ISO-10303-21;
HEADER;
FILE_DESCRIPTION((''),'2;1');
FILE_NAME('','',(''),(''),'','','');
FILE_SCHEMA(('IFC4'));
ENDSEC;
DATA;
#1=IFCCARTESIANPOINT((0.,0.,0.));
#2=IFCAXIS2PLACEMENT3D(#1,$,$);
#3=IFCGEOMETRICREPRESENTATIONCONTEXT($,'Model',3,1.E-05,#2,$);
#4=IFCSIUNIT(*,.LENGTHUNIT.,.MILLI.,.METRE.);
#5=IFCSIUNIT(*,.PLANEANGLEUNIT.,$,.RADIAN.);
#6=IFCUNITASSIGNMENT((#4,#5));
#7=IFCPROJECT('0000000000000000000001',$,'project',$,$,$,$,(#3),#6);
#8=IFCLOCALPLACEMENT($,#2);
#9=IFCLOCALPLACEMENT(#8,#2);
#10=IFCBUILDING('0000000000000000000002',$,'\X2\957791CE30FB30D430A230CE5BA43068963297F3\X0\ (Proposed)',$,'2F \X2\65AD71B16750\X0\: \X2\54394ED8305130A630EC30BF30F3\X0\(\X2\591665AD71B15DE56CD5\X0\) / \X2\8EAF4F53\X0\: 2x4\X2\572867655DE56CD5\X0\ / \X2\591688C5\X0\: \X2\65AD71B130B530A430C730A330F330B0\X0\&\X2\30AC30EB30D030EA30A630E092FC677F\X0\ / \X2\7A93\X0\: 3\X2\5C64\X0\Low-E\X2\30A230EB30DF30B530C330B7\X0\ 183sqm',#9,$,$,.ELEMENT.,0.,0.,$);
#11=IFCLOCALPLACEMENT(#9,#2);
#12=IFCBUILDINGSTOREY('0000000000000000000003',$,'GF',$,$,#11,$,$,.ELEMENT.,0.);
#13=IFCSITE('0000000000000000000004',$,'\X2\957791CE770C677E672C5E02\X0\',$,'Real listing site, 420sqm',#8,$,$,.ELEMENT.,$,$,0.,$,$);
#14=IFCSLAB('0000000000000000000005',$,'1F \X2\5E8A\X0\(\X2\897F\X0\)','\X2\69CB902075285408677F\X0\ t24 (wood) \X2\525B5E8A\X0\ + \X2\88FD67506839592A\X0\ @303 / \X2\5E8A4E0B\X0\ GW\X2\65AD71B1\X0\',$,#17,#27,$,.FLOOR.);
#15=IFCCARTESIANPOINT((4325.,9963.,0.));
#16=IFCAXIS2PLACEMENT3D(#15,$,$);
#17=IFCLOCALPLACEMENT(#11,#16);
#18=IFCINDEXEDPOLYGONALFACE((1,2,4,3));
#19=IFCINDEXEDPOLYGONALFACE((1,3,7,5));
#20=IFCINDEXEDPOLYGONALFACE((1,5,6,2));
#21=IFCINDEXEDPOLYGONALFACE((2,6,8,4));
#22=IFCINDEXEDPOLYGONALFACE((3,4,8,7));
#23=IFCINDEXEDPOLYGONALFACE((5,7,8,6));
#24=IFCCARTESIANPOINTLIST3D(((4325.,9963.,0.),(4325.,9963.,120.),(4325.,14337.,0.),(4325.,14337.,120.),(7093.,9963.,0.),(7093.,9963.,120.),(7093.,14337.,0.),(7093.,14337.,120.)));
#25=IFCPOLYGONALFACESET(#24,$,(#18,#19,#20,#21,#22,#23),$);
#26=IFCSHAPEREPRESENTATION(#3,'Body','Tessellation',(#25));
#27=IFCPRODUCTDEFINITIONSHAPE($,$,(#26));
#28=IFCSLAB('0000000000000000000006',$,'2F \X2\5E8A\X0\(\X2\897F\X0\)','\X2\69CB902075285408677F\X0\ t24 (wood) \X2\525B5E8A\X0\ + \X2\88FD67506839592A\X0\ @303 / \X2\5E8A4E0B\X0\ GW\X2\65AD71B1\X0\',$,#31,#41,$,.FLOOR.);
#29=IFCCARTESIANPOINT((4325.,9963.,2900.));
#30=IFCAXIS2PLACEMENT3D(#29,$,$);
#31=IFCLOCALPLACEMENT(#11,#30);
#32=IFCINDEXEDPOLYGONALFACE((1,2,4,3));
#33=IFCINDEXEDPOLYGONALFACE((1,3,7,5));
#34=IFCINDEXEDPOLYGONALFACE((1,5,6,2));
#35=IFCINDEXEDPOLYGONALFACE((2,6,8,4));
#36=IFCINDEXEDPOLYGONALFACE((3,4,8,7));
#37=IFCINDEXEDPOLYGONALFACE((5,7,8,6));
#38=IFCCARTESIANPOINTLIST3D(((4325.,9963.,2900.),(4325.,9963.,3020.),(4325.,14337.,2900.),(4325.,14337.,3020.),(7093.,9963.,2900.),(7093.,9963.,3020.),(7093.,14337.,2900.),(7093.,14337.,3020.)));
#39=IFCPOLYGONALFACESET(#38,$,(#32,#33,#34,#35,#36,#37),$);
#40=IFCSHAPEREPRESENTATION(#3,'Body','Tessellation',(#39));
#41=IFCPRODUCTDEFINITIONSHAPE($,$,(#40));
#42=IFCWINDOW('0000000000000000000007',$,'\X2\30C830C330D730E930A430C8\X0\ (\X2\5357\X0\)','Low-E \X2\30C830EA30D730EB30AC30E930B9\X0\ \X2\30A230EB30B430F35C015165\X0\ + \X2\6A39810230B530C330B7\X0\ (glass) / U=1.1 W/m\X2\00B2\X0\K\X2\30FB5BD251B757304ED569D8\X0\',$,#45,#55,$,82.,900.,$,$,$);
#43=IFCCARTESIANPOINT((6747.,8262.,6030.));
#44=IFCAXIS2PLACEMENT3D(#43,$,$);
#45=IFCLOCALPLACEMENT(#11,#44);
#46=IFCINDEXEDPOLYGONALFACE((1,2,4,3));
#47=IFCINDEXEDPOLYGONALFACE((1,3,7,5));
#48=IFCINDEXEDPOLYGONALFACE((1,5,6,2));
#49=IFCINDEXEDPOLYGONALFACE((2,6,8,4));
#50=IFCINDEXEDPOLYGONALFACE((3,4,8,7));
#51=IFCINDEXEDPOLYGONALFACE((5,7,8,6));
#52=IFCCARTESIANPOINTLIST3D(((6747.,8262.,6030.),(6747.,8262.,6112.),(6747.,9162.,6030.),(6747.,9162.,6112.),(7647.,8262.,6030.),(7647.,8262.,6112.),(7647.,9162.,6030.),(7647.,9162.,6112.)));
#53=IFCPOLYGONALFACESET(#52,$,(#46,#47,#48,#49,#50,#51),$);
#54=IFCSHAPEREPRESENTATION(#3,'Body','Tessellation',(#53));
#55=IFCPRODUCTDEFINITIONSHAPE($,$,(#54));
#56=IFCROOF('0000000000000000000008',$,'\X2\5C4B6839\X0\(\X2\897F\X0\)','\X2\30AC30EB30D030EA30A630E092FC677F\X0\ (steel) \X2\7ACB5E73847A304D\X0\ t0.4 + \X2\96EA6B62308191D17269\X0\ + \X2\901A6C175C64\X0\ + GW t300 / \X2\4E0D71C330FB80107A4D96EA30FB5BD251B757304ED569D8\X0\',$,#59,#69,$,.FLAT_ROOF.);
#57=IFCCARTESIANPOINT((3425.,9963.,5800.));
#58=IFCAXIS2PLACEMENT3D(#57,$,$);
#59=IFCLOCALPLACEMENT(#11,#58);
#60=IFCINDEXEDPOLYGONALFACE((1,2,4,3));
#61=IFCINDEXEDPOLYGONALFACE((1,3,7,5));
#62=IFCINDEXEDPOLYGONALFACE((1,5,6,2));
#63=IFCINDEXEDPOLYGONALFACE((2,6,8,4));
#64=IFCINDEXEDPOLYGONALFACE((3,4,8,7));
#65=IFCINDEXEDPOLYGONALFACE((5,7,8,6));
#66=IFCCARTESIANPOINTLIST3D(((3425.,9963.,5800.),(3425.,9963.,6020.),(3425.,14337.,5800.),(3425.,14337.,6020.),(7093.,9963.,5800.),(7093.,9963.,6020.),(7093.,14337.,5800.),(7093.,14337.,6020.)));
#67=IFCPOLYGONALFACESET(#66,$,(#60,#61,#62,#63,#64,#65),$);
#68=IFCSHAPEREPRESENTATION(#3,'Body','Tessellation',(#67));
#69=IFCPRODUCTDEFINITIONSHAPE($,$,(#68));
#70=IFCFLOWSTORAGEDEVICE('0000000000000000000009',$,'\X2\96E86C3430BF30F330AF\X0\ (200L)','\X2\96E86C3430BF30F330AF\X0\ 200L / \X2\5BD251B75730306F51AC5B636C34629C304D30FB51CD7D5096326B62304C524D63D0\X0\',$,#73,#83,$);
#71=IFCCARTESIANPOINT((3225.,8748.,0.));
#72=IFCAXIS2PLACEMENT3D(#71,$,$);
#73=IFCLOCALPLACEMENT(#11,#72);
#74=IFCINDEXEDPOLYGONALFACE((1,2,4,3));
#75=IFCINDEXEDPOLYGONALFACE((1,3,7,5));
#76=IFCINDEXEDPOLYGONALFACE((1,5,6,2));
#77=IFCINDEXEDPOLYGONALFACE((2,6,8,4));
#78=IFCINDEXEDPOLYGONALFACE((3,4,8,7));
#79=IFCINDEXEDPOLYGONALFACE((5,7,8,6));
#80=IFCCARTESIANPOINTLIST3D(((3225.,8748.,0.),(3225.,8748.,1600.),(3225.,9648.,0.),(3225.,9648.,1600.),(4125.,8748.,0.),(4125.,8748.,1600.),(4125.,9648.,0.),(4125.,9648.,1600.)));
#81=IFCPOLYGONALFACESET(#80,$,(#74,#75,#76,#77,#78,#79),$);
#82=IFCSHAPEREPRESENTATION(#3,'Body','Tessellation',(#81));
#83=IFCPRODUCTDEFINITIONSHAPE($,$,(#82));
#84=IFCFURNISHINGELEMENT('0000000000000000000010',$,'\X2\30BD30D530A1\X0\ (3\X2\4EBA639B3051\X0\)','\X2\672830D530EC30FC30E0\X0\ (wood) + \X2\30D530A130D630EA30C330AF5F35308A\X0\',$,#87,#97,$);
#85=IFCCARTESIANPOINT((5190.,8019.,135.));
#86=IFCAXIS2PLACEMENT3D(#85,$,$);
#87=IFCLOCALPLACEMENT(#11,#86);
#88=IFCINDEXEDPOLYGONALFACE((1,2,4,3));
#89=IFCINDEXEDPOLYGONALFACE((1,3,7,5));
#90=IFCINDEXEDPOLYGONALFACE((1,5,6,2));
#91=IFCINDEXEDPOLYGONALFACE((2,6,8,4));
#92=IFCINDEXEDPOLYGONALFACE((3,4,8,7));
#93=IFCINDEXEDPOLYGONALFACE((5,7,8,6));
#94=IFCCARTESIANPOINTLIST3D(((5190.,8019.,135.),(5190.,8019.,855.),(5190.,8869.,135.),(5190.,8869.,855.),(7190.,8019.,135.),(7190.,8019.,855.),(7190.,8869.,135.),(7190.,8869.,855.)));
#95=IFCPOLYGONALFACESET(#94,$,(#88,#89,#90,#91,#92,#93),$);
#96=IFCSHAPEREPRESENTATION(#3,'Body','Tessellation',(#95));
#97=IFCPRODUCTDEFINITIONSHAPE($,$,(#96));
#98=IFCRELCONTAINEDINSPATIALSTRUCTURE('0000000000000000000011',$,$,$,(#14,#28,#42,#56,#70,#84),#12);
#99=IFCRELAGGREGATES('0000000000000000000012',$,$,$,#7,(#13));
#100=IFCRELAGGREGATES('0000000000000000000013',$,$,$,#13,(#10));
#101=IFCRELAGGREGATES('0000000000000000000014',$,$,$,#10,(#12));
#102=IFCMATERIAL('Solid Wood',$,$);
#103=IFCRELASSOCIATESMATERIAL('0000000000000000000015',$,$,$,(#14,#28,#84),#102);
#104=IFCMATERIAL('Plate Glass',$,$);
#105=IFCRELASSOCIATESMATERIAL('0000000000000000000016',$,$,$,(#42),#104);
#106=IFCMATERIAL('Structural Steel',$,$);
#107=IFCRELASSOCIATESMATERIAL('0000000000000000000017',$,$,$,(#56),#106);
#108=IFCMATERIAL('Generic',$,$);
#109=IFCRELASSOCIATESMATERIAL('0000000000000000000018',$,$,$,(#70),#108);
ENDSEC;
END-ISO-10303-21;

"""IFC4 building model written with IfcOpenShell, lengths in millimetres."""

from ifc_helpers import new_model, si_unit, frame, frame_2d, origin, place, context, project, spatial, rectangle, extrude, material, element, save


model = new_model("IFC4")

# Units and contexts
model_context = context("Model", 3, precision=1e-05, world=origin())
ifc_project = project(units=[si_unit("LENGTHUNIT", "METRE", prefix="MILLI"), si_unit("PLANEANGLEUNIT", "RADIAN")], contexts=[model_context])

# Site, building, storey
site_placement = place(None, origin())
site = spatial("IfcSite", under=ifc_project, at=site_placement, Name="長野県松本市", ObjectType="Real listing site, 420sqm", CompositionType="ELEMENT", RefElevation=0.0)
building_placement = place(site_placement, origin())
building = spatial("IfcBuilding", under=site, at=building_placement, Name="長野・ピアノ室と防音 (Proposed)", ObjectType="2F 断熱材: 吹付けウレタン(外断熱工法) / 躯体: 2x4在来工法 / 外装: 断熱サイディング&ガルバリウム鋼板 / 窓: 3層Low-Eアルミサッシ 183sqm", CompositionType="ELEMENT", ElevationOfRefHeight=0.0, ElevationOfTerrain=0.0)
storey_placement = place(building_placement, origin())
storey = spatial("IfcBuildingStorey", under=building, at=storey_placement, Name="GF", CompositionType="ELEMENT", Elevation=0.0)

# Shared definitions
ifc_material_1 = material(Name="Solid Wood")

# Slabs
slab_1_placement = place(storey_placement, frame((4325.0, 9963.0, 0.0)))
element("IfcSlab", 1, at=slab_1_placement, inside=storey, material=ifc_material_1, Name="1F 床(西)", Description="構造用合板 t24 (wood) 剛床 + 製材根太 @303 / 床下 GW断熱", PredefinedType="FLOOR", context=model_context, shape_type="SweptSolid", body=[
    extrude(rectangle(XDim=2768.0, YDim=4374.0, at=frame_2d((1384.0, 2187.0))), frame((4325.0, 9963.0, 0.0)), (0.0, 0.0, 1.0), 120.0),
])
slab_2_placement = place(storey_placement, frame((4325.0, 9963.0, 2900.0)))
element("IfcSlab", 2, at=slab_2_placement, inside=storey, material=ifc_material_1, Name="2F 床(西)", Description="構造用合板 t24 (wood) 剛床 + 製材根太 @303 / 床下 GW断熱", PredefinedType="FLOOR", context=model_context, shape_type="SweptSolid", body=[
    extrude(rectangle(XDim=2768.0, YDim=4374.0, at=frame_2d((1384.0, 2187.0))), frame((4325.0, 9963.0, 2900.0)), (0.0, 0.0, 1.0), 120.0),
])

# Window
ifc_material_2 = material(Name="Plate Glass")
window_placement = place(storey_placement, frame((6747.0, 8262.0, 6030.0)))
element("IfcWindow", 3, at=window_placement, inside=storey, material=ifc_material_2, Name="トップライト (南)", Description="Low-E トリプルガラス アルゴン封入 + 樹脂サッシ (glass) / U=1.1 W/m²K・寒冷地仕様", OverallHeight=82.0, OverallWidth=900.0, context=model_context, shape_type="SweptSolid", body=[
    extrude(rectangle(XDim=900.0, YDim=900.0, at=frame_2d((450.0, 450.0))), frame((6747.0, 8262.0, 6030.0)), (0.0, 0.0, 1.0), 82.0),
])

# Roof
ifc_material_3 = material(Name="Structural Steel")
for number, where, name in (
    (4, (3425.0, 9963.0, 5800.0), "屋根(西)"),
):
    element("IfcRoof", number, at=place(storey_placement, frame(where)), inside=storey, material=ifc_material_3, Name=name, Description="ガルバリウム鋼板 (steel) 立平葺き t0.4 + 雪止め金物 + 通気層 + GW t300 / 不燃・耐積雪・寒冷地仕様", PredefinedType="FLAT_ROOF", context=model_context, shape_type="SweptSolid", body=[
        extrude(rectangle(XDim=3668.0, YDim=4374.0, at=frame_2d((1834.0, 2187.0))), frame((3425.0, 9963.0, 5800.0)), (0.0, 0.0, 1.0), 220.0),
    ])

# Flow storage device
ifc_material_4 = material(Name="Generic")
flow_storage_device_placement = place(storey_placement, frame((3225.0, 8748.0, 0.0)))
element("IfcFlowStorageDevice", 5, at=flow_storage_device_placement, inside=storey, material=ifc_material_4, Name="雨水タンク (200L)", Description="雨水タンク 200L / 寒冷地は冬季水抜き・凍結防止が前提", context=model_context, shape_type="SweptSolid", body=[
    extrude(rectangle(XDim=900.0, YDim=900.0, at=frame_2d((450.0, 450.0))), frame((3225.0, 8748.0, 0.0)), (0.0, 0.0, 1.0), 1600.0),
])

# Furnishing element
furnishing_placement = place(storey_placement, frame((5190.0, 8019.0, 135.0)))
element("IfcFurnishingElement", 6, at=furnishing_placement, inside=storey, material=ifc_material_1, Name="ソファ (3人掛け)", Description="木フレーム (wood) + ファブリック張り", context=model_context, shape_type="SweptSolid", body=[
    extrude(rectangle(XDim=2000.0, YDim=850.0, at=frame_2d((1000.0, 425.0))), frame((5190.0, 8019.0, 135.0)), (0.0, 0.0, 1.0), 720.0),
])

save(model, "model.ifc")
